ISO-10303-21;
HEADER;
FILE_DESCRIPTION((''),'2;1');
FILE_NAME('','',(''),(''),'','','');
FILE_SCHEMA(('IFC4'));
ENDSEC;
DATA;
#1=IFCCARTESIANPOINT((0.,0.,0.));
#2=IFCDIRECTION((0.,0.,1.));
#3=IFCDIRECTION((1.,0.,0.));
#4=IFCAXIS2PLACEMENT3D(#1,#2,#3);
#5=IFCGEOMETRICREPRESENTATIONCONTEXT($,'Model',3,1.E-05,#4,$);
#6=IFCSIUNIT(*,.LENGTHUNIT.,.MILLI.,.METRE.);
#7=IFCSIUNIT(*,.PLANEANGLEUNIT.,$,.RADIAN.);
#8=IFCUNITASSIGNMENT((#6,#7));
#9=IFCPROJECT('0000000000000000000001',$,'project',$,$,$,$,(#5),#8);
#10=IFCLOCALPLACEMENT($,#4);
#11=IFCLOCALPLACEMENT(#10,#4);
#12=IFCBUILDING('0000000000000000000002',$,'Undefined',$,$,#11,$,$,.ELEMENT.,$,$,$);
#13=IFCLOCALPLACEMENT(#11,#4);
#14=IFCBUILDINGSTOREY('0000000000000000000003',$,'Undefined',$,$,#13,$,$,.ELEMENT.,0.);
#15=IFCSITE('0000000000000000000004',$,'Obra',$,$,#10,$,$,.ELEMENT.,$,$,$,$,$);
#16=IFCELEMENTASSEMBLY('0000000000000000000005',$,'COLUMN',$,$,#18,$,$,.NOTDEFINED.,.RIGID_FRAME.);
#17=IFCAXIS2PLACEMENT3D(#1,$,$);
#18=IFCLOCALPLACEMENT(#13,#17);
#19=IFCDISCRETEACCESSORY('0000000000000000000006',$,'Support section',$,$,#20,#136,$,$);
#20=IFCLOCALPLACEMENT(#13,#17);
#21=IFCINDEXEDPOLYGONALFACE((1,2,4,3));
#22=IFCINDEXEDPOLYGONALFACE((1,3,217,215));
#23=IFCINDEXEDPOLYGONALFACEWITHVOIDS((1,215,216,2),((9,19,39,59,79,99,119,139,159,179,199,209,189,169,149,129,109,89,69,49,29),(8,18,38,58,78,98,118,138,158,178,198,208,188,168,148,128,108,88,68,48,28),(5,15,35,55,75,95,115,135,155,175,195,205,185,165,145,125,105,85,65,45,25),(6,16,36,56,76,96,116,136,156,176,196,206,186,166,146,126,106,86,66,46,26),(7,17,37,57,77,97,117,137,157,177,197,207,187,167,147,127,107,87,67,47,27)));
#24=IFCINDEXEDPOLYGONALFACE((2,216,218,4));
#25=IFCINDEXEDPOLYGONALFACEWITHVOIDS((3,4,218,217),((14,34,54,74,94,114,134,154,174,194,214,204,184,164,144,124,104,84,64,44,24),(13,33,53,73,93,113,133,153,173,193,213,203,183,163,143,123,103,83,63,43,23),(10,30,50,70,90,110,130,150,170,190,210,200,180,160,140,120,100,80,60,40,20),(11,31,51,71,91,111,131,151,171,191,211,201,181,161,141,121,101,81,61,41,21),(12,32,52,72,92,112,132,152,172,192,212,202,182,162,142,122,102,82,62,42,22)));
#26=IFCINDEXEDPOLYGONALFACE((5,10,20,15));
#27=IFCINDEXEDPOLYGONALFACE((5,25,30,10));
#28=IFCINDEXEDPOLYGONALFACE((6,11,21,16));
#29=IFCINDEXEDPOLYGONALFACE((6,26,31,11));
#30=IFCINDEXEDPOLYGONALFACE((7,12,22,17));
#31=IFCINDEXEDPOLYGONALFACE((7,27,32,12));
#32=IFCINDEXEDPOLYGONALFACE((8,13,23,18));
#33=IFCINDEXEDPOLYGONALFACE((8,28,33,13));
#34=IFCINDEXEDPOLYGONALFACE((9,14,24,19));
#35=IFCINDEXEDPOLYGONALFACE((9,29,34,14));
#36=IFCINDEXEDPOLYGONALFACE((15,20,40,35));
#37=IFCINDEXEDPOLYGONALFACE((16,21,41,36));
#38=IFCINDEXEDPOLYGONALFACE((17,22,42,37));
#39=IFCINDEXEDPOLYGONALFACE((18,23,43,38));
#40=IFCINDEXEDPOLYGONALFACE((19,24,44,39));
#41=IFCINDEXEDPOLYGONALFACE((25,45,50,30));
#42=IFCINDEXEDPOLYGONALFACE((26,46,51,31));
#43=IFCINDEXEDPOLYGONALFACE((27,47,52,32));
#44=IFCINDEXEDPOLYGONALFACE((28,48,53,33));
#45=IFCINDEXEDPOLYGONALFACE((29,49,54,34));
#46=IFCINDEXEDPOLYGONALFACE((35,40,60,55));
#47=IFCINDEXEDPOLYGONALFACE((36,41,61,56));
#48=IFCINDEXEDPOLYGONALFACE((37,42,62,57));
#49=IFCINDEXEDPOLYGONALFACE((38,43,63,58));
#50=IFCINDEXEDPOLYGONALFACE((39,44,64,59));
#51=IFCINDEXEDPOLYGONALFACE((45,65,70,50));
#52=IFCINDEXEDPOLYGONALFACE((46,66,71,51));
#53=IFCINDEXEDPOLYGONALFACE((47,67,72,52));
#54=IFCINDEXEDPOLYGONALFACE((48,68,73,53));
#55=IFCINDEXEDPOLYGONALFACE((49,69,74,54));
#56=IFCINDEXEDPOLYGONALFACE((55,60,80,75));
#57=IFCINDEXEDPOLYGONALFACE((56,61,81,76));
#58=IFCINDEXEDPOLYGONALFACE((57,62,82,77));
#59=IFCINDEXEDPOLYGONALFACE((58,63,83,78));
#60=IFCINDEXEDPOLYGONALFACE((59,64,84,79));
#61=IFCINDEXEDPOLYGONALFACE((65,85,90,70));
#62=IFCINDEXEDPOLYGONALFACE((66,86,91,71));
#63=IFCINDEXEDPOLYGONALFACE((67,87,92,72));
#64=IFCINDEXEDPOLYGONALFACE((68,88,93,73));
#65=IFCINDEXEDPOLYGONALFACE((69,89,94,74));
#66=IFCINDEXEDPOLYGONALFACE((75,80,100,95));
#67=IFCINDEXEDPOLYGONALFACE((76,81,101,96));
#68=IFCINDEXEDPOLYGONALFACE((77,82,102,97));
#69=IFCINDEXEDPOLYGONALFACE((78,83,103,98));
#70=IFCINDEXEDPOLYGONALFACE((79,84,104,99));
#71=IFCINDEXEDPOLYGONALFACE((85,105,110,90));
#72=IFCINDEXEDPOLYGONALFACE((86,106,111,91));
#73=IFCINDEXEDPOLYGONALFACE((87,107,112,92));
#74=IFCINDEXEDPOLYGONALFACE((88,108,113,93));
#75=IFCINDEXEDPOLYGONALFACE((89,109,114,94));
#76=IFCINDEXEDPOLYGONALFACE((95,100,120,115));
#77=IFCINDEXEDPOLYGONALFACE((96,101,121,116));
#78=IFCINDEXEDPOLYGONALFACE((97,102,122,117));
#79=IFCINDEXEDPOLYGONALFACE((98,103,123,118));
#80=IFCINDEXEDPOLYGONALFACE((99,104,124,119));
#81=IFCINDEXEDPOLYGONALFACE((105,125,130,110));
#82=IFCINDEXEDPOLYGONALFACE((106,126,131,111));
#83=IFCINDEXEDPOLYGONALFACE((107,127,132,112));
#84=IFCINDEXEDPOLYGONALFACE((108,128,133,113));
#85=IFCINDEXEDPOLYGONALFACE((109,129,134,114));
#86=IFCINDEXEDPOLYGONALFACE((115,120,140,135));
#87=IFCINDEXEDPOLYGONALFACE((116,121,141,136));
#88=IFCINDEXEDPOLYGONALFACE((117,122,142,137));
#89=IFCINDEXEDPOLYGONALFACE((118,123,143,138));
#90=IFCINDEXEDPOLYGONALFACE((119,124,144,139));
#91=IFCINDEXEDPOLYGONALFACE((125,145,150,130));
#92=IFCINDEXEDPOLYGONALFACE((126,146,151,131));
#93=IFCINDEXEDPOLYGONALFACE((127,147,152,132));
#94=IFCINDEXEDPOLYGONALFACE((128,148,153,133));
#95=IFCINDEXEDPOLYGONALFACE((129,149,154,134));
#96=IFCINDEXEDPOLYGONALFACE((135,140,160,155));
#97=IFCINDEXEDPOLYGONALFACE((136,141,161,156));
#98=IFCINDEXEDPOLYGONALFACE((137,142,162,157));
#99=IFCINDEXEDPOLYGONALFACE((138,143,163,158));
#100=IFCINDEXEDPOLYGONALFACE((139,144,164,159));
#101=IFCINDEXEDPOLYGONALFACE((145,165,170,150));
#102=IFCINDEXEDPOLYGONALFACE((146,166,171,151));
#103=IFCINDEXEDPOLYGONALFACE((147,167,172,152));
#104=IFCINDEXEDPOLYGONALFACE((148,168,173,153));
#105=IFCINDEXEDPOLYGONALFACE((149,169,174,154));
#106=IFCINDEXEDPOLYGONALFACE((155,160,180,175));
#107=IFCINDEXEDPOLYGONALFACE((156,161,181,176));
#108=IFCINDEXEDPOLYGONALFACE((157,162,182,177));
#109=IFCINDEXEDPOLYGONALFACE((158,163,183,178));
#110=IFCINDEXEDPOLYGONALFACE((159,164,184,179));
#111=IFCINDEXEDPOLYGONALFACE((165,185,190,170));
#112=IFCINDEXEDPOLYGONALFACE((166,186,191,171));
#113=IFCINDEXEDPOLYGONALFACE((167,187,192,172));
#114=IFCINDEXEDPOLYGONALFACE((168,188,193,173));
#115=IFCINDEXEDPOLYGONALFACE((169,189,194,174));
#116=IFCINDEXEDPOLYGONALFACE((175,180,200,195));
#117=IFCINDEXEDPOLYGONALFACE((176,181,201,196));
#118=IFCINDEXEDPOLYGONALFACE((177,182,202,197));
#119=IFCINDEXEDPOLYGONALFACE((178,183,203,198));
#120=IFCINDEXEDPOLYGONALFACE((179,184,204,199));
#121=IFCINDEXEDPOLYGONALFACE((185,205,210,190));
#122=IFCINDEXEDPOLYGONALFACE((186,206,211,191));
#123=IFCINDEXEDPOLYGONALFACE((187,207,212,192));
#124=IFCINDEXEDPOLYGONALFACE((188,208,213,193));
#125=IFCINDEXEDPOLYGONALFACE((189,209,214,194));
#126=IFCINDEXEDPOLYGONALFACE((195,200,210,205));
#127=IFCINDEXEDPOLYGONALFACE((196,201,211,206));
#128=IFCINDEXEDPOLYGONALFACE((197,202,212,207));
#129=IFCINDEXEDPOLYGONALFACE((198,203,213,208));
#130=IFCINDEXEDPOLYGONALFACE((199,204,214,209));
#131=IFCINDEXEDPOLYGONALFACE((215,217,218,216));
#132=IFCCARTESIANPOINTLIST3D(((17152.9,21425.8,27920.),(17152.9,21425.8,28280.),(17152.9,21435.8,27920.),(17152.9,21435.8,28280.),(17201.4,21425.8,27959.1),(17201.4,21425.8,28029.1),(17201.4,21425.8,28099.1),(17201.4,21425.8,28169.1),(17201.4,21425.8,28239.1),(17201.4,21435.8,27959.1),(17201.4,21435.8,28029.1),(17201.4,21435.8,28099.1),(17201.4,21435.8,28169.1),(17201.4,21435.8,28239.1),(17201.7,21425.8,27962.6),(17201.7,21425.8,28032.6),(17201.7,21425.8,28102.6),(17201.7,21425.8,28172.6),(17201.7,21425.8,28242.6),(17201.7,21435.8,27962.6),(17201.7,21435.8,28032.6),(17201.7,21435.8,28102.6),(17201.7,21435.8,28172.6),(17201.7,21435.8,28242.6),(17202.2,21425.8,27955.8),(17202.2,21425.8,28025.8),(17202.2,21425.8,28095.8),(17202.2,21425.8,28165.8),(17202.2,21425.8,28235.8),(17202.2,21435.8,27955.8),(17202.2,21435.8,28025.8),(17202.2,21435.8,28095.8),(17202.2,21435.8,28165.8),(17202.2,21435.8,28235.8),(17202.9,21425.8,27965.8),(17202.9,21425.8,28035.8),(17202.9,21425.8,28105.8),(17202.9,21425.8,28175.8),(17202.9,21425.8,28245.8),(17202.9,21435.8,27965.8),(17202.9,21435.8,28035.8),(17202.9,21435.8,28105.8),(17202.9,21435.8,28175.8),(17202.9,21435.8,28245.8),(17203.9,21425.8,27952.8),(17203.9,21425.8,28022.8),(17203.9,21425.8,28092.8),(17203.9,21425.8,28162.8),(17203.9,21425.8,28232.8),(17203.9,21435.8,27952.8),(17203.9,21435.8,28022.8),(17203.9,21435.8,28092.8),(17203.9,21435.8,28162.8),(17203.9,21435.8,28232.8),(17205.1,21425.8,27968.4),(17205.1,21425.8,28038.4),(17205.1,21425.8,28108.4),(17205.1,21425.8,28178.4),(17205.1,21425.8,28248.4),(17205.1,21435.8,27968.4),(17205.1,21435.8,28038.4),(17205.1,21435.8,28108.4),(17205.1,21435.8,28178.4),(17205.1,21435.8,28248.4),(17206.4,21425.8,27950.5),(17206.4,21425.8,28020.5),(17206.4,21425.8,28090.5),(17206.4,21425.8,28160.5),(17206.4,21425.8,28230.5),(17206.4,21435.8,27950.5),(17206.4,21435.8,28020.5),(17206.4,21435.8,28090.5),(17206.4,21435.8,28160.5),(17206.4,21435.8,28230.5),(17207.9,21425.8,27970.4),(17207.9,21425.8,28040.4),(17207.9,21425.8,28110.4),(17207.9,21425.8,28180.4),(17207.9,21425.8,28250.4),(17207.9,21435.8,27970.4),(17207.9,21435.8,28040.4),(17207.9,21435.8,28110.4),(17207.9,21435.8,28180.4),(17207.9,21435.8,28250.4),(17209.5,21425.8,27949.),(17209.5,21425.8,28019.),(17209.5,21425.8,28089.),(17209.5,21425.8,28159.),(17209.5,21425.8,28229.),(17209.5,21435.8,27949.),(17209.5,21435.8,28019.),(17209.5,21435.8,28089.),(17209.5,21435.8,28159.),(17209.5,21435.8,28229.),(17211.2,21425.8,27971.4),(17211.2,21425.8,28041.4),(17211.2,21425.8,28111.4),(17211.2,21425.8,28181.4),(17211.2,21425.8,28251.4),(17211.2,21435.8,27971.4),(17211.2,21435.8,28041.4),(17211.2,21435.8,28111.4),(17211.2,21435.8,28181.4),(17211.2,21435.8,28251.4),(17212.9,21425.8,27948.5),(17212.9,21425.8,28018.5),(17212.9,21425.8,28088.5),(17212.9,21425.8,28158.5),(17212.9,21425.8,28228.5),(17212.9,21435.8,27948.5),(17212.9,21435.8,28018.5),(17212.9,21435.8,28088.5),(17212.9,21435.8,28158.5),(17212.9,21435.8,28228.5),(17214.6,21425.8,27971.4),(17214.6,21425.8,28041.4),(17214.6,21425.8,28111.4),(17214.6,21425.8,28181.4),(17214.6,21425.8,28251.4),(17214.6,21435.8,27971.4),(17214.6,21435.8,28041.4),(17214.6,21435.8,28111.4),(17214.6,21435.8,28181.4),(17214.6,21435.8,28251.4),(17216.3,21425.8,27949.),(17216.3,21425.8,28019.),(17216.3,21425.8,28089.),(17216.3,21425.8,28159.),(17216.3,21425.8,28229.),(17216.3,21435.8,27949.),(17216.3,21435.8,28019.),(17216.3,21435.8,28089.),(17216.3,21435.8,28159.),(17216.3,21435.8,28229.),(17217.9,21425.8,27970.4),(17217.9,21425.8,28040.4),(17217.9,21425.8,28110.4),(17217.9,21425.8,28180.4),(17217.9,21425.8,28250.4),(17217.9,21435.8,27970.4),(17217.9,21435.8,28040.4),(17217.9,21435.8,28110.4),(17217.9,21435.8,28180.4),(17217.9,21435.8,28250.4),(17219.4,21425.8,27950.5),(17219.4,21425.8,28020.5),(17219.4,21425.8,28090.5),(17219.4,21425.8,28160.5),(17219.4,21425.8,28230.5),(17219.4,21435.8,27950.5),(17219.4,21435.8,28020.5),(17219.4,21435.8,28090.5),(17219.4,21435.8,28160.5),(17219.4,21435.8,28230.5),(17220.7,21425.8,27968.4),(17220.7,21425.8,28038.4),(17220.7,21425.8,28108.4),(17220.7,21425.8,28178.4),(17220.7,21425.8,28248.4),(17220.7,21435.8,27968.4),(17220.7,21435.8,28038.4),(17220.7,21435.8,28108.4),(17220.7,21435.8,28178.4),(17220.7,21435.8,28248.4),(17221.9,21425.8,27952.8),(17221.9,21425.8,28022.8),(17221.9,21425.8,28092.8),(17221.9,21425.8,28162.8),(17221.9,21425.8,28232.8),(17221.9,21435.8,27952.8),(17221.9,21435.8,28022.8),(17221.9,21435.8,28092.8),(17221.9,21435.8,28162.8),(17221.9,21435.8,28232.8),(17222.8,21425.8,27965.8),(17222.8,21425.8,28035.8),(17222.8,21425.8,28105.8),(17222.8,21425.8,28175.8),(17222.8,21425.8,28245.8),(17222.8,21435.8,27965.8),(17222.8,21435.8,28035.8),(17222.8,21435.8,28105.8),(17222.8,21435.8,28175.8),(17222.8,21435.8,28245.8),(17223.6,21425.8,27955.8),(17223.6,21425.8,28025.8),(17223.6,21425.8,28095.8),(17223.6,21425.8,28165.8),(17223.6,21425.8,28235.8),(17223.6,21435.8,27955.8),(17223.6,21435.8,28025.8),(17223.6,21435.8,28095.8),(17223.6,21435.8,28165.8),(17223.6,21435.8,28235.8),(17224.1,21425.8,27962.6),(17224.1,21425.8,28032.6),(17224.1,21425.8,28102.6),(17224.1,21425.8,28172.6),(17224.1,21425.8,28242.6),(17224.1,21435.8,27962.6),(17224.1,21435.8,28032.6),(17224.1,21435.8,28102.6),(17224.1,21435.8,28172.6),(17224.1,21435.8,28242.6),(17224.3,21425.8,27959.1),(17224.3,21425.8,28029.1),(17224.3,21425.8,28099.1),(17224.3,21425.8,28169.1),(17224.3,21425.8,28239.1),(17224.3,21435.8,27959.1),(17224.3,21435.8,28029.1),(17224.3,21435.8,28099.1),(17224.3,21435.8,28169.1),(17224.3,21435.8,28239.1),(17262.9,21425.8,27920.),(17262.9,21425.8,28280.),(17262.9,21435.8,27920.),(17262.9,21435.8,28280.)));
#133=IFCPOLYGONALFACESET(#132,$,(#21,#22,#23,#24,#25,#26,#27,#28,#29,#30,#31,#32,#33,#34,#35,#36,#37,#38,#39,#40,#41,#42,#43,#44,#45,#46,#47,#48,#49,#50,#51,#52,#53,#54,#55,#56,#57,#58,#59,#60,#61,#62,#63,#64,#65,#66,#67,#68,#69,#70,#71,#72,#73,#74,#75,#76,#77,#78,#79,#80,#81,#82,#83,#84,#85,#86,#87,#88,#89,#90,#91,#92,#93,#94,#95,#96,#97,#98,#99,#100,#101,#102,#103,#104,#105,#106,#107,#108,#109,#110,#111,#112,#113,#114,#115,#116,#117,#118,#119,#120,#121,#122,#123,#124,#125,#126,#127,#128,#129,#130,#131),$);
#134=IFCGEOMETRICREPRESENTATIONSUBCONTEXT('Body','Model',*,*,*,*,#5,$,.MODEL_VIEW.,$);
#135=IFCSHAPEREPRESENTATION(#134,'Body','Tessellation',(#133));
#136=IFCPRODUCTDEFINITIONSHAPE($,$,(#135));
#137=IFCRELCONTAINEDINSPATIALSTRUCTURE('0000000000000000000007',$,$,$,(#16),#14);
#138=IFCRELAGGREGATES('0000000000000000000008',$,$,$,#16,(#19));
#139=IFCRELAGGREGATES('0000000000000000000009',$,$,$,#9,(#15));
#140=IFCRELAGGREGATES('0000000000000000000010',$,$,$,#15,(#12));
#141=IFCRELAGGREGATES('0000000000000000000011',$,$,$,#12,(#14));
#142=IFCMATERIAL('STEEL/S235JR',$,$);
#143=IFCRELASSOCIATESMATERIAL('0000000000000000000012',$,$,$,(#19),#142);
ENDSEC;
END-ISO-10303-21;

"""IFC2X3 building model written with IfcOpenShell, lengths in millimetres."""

from ifc_helpers import new_model, si_unit, frame, origin_with_axes, origin_2d_with_axis, place, context, subcontext, project, spatial, rectangle, circle, extrude, source, transform, mapped, material, element, aggregate, save


model = new_model("IFC2X3")

# Units and contexts
model_context = context("Model", 3, precision=1e-05, world=origin_with_axes())
body_context = subcontext(model_context, "Body", "Model", "MODEL_VIEW")
ifc_project = project(units=[si_unit("LENGTHUNIT", "METRE", prefix="MILLI"), si_unit("PLANEANGLEUNIT", "RADIAN")], contexts=[model_context])

# Site, building, storey
site_placement = place(None, origin_with_axes())
site = spatial("IfcSite", under=ifc_project, at=site_placement, Name="Obra", CompositionType="ELEMENT")
building_placement = place(site_placement, origin_with_axes())
building = spatial("IfcBuilding", under=site, at=building_placement, Name="Undefined", CompositionType="ELEMENT")
storey_placement = place(building_placement, origin_with_axes())
storey = spatial("IfcBuildingStorey", under=building, at=storey_placement, Name="Undefined", CompositionType="ELEMENT", Elevation=0.0)

# Shared definitions
ifc_material = material(Name="STEEL/S235JR")

# Element assembly, discrete accessory, opening
assembly_1_placement = place(storey_placement, origin_with_axes())
assembly_1 = element("IfcElementAssembly", 1, at=assembly_1_placement, inside=storey, Name="COLUMN", AssemblyPlace="NOTDEFINED", PredefinedType="RIGID_FRAME")
discrete_accessory_1_placement = place(assembly_1_placement, frame((17207.9, 21430.8, 27920.0), z_axis=(0.0, 0.0, 1.0), x_axis=(-1.0, 0.0, 0.0)))
discrete_accessory_1 = element("IfcDiscreteAccessory", 2, at=discrete_accessory_1_placement, material=ifc_material, Name="Support section", context=body_context, shape_type="SweptSolid", body=[
    extrude(rectangle(XDim=10.0, YDim=110.0, at=origin_2d_with_axis()), frame((0.0, 0.0, 360.0), z_axis=(0.0, 0.0, -1.0), x_axis=(0.0, 1.0, 0.0)), (0.0, 0.0, 1.0), 360.0),
])
shared_shape_1 = source(origin_with_axes(), body_context, "Body", "SweptSolid", [
    extrude(circle(Radius=11.5, at=origin_2d_with_axis()), frame((0.0, -14.4, 0.0), z_axis=(0.0, 1.0, 0.0), x_axis=(1.0, 0.0, 0.0)), (0.0, 0.0, 1.0), 10.2),
])
opening_1_placement = place(assembly_1_placement, frame((17162.9, 21440.1, 28300.0), z_axis=(1.0, 0.0, 0.0), x_axis=(0.0, 0.0, -1.0)))
element("IfcOpeningElement", 3, at=opening_1_placement, cuts=discrete_accessory_1, ObjectType="Opening", context=body_context, shape_type="MappedRepresentation", body=[
    mapped(shared_shape_1, transform((60.0, 0.0, 50.0))),
    mapped(shared_shape_1, transform((130.0, 0.0, 50.0))),
    mapped(shared_shape_1, transform((200.0, 0.0, 50.0))),
    mapped(shared_shape_1, transform((270.0, 0.0, 50.0))),
    mapped(shared_shape_1, transform((340.0, 0.0, 50.0))),
])
aggregate(assembly_1, [discrete_accessory_1])

save(model, "model.ifc")
